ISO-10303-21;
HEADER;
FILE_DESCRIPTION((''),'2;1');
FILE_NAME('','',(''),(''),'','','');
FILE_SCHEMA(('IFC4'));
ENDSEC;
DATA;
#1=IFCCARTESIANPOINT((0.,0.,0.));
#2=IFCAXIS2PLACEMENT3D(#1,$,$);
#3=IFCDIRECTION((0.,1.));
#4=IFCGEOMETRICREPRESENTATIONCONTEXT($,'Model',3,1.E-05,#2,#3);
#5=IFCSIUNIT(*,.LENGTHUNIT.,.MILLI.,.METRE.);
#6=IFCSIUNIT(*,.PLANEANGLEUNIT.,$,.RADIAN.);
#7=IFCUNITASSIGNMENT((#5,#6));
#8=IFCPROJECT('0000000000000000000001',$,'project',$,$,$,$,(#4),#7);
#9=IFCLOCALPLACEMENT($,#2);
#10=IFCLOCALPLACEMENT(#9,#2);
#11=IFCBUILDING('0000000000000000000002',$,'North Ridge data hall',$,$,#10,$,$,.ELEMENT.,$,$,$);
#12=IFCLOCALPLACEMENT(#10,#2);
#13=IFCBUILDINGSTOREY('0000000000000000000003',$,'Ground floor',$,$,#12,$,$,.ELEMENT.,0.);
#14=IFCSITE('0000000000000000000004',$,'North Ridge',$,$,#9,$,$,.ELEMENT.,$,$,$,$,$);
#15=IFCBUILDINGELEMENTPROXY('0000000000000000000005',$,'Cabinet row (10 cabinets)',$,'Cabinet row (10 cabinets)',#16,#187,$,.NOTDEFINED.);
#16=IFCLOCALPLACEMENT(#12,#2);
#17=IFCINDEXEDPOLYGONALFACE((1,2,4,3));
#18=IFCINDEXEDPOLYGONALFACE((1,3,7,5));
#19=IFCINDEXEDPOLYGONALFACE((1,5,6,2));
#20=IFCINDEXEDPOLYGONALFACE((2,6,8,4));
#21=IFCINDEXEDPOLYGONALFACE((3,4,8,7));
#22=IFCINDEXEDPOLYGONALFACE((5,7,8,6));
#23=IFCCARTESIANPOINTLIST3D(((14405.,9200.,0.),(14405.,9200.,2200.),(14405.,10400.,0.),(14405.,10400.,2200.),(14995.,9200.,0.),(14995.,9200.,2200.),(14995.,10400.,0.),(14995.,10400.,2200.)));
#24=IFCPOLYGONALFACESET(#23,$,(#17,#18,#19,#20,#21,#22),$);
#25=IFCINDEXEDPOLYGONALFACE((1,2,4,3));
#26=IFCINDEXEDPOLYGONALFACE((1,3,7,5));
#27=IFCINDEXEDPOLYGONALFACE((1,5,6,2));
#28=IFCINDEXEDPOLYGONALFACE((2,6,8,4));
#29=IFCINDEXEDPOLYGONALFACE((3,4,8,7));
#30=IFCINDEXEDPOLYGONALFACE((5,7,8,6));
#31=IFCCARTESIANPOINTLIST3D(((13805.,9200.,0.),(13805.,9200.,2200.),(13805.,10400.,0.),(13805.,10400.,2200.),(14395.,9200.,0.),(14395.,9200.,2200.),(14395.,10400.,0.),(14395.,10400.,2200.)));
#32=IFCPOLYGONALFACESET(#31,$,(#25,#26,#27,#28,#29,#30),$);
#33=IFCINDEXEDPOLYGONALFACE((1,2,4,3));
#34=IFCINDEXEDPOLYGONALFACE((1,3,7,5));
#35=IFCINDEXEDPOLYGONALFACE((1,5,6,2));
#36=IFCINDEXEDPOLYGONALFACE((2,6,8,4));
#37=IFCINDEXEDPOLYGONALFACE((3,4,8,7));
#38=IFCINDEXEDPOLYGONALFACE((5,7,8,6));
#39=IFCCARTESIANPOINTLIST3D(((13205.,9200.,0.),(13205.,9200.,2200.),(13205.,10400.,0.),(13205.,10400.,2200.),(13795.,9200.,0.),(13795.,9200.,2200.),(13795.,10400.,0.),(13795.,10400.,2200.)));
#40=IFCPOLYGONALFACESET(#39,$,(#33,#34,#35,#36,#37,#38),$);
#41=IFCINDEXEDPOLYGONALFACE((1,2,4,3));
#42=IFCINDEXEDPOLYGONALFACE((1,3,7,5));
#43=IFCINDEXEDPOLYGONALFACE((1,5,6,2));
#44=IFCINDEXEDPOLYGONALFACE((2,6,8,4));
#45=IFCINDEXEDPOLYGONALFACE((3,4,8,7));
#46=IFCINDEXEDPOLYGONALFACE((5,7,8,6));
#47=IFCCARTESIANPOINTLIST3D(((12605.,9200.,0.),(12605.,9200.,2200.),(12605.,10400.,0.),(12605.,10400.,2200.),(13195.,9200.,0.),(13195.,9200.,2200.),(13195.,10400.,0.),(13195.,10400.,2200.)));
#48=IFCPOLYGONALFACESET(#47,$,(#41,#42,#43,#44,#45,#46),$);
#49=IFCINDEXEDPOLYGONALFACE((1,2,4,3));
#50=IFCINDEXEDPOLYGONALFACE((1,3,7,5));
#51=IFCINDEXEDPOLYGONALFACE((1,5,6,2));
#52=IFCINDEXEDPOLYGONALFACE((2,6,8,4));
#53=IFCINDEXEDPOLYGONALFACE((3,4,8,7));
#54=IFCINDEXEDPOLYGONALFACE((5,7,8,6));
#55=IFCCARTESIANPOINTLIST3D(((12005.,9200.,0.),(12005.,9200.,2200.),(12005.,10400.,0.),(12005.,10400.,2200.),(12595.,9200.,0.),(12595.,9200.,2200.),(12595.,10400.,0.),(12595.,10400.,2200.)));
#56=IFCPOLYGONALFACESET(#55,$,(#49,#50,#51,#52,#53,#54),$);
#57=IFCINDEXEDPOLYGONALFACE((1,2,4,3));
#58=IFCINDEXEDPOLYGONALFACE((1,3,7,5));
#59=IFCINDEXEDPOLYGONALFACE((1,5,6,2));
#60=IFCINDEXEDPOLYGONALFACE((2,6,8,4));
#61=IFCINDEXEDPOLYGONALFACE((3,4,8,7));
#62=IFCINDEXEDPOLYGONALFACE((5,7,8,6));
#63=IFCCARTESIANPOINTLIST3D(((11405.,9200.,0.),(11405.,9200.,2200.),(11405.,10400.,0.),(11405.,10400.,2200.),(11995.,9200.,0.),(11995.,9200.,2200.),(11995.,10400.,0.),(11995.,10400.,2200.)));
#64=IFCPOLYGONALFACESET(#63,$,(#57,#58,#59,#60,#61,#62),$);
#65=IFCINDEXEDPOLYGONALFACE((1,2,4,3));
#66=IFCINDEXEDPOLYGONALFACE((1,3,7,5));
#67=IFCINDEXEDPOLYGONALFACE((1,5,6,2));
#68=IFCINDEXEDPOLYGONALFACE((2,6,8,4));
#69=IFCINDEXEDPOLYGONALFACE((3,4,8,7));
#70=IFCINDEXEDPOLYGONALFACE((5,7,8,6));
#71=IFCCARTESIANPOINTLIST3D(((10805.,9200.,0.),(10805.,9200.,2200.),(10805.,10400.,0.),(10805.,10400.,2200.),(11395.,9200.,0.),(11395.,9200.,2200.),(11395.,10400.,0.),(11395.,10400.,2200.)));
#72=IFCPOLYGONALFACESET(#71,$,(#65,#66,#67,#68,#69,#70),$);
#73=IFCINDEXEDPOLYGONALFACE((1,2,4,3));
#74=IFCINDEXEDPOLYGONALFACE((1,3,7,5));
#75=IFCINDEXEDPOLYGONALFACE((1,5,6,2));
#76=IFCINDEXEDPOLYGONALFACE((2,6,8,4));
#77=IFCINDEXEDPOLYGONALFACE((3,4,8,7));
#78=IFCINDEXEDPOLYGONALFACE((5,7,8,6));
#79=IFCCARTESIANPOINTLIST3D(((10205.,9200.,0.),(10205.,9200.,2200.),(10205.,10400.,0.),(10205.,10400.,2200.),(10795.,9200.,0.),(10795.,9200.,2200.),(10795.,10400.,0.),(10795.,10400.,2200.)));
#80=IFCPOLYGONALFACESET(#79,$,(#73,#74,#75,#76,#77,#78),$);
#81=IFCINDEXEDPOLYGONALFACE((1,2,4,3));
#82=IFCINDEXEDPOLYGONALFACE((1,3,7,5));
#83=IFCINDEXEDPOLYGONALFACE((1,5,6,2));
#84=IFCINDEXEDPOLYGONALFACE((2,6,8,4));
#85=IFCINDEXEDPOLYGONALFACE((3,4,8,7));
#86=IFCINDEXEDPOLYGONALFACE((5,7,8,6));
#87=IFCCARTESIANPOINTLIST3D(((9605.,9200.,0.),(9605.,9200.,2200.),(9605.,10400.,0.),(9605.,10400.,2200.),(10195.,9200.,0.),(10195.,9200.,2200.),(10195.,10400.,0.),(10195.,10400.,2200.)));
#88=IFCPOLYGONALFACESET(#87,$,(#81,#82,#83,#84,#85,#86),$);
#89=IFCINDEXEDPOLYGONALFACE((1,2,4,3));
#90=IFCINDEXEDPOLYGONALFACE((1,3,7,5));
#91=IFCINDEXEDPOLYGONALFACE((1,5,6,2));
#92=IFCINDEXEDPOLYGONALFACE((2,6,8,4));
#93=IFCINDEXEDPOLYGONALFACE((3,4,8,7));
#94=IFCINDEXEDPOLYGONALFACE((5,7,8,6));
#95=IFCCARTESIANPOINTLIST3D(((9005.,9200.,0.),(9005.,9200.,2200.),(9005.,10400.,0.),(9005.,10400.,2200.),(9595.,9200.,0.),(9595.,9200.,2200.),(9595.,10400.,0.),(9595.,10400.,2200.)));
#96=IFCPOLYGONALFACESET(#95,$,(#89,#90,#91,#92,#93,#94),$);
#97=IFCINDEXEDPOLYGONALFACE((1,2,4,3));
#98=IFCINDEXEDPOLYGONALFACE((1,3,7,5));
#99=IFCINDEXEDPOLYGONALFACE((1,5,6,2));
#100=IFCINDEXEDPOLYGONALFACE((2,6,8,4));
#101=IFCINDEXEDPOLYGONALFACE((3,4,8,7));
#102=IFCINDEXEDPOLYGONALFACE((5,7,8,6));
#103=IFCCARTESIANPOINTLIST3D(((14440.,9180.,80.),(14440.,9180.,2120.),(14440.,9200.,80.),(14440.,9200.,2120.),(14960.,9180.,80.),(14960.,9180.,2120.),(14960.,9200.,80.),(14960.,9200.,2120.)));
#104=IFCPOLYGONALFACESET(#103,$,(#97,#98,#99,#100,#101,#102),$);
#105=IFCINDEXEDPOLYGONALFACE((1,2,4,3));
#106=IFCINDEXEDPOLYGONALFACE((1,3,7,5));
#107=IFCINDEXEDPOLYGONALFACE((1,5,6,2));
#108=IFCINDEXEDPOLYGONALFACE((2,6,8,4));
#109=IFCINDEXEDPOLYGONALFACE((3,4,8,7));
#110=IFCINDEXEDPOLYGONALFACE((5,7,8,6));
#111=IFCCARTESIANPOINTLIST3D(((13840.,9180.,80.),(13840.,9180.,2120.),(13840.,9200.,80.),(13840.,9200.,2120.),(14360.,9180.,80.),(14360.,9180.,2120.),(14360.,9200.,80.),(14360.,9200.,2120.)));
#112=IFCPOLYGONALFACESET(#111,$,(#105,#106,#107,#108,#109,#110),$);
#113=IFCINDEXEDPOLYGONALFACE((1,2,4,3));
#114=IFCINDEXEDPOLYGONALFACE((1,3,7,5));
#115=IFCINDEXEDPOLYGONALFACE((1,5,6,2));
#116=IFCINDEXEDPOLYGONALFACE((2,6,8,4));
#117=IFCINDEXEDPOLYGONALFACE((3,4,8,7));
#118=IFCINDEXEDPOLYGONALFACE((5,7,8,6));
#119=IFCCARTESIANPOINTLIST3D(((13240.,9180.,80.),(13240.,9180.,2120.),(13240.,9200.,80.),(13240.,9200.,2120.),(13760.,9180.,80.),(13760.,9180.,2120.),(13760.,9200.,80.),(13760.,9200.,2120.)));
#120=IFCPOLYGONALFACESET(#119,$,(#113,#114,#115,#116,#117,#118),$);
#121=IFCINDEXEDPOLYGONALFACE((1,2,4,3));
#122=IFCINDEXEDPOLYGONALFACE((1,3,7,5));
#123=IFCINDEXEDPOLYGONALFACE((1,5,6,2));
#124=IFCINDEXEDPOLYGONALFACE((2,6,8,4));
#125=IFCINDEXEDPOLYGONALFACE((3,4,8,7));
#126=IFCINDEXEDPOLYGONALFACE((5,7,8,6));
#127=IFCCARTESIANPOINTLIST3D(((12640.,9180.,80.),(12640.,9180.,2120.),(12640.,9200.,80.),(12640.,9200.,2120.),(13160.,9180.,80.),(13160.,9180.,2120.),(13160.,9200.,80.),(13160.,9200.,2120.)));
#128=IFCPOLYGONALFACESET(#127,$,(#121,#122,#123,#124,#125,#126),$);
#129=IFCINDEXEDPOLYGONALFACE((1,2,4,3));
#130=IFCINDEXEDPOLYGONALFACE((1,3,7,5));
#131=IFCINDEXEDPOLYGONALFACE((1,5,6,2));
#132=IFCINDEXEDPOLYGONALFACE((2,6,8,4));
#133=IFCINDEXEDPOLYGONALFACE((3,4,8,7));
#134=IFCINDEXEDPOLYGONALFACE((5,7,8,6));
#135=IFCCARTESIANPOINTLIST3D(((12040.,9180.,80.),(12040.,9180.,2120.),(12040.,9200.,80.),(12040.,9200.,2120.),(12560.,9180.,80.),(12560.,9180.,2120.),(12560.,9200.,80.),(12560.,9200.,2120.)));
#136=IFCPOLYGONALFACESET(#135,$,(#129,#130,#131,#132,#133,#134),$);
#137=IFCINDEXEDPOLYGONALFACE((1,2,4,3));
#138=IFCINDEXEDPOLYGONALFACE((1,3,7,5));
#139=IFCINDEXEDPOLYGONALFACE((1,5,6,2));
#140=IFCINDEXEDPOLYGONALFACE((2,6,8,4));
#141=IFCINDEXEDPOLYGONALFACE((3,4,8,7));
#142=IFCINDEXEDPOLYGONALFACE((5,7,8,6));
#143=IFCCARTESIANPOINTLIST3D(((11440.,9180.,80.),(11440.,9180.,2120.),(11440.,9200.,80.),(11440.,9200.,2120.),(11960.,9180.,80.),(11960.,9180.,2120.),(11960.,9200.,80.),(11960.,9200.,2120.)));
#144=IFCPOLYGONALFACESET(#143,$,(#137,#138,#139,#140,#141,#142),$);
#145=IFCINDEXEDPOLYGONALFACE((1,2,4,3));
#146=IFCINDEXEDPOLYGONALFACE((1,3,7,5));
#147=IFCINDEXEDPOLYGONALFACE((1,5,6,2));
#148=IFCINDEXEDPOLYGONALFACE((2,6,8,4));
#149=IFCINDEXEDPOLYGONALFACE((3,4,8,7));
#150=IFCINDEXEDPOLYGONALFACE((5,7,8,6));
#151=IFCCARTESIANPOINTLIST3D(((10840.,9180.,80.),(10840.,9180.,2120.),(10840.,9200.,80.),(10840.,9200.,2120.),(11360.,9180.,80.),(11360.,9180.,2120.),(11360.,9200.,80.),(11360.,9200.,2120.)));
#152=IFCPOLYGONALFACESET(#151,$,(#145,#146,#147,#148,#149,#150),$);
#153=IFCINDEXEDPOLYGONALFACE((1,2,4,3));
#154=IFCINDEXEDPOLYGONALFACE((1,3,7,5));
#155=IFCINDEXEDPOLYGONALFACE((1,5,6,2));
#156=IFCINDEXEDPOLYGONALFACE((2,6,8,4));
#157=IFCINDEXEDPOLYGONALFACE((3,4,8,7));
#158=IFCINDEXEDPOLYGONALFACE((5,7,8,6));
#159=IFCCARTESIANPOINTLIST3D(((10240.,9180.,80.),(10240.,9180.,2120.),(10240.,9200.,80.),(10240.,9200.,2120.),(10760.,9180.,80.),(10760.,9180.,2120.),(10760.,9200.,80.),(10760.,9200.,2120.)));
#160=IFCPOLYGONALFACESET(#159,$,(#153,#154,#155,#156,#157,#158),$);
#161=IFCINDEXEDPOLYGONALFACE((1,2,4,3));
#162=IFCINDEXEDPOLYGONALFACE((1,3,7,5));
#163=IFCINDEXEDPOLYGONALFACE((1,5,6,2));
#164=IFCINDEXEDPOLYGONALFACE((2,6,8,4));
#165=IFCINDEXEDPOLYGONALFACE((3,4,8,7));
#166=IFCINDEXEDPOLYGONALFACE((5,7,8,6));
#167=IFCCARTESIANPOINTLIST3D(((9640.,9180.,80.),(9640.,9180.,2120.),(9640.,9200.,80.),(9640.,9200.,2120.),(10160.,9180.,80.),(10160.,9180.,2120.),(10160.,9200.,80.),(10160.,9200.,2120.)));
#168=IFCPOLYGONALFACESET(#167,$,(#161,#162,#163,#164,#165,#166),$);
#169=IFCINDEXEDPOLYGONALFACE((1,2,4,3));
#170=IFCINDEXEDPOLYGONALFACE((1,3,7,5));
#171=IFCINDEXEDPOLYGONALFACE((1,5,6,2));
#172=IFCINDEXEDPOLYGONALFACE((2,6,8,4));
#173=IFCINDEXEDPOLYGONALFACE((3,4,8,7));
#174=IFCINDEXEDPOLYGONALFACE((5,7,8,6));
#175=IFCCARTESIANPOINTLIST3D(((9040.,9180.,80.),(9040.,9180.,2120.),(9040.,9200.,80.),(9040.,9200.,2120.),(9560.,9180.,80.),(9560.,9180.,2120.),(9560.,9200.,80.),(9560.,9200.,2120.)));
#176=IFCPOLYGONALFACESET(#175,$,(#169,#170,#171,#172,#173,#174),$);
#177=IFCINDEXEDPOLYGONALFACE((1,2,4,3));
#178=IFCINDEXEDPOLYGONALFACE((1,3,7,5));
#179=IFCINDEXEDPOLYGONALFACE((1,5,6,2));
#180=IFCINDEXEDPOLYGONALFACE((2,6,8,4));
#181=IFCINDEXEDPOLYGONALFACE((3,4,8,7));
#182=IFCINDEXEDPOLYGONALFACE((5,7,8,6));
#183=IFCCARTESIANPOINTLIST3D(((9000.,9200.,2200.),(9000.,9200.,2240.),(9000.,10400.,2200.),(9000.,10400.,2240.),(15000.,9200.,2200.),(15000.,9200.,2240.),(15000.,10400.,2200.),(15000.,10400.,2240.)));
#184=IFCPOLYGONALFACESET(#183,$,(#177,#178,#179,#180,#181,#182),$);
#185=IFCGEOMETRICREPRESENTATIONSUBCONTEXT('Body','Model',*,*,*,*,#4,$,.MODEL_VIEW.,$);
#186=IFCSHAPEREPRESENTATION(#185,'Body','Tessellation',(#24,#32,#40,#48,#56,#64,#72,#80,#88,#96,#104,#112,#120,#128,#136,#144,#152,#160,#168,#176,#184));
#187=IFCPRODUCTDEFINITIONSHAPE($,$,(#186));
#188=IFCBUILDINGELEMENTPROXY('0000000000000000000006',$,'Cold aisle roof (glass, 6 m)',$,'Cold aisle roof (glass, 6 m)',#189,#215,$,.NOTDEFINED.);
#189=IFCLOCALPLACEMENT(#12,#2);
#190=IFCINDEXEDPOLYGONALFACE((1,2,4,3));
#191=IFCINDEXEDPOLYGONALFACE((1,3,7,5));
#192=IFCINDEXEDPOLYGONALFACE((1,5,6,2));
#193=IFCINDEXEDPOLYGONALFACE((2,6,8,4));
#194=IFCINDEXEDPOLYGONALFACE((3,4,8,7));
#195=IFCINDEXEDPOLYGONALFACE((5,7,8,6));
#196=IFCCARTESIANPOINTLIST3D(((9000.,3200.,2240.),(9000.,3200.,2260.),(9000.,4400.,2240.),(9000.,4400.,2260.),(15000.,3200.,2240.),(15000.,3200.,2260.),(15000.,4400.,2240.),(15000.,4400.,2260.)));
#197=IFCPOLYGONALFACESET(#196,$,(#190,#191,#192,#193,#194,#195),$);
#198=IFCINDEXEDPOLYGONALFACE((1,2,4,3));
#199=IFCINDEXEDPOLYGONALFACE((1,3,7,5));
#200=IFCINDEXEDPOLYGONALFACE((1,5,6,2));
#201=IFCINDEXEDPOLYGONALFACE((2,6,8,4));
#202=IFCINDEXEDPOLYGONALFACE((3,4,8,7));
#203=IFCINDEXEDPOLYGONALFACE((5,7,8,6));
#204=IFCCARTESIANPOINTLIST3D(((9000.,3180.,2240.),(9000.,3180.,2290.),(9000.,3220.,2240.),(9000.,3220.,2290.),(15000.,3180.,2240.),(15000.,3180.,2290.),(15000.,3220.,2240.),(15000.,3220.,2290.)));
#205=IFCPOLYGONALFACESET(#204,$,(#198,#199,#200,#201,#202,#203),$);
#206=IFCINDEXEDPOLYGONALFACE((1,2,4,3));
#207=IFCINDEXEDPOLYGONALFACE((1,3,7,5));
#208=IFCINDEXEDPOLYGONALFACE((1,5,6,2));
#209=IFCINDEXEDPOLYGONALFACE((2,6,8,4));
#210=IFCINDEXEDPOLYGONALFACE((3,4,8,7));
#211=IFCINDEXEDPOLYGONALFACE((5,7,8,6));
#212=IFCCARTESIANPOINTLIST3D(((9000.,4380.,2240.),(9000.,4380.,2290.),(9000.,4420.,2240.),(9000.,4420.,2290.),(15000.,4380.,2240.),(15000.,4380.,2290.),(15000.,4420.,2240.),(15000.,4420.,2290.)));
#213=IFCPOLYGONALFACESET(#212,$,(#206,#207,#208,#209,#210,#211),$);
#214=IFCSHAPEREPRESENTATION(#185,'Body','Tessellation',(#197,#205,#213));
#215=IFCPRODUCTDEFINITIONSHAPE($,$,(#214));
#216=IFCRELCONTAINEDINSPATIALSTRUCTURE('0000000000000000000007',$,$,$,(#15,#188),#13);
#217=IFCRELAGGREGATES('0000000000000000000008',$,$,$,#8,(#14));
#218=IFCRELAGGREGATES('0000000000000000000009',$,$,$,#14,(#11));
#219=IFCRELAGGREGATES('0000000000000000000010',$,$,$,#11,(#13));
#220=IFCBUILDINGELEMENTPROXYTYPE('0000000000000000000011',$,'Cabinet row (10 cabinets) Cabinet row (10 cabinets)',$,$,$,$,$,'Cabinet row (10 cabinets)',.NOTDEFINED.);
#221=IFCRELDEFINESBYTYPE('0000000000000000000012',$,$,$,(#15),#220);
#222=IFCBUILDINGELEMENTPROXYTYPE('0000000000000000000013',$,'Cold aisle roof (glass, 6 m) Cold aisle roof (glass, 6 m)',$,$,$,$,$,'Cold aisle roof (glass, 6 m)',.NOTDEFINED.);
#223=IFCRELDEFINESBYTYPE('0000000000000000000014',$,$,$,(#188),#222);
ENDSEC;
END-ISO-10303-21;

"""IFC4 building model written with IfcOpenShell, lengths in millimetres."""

from ifc_helpers import new_model, si_unit, direction, frame, origin, place, context, subcontext, project, spatial, polyline, outline, extrude, source, transform, mapped, type_object, type_shapes, element, save


model = new_model("IFC4")

# Units and contexts
model_context = context("Model", 3, precision=1e-05, world=origin(), true_north=direction((0.0, 1.0)))
body_context = subcontext(model_context, "Body", "Model", "MODEL_VIEW")
ifc_project = project(units=[si_unit("LENGTHUNIT", "METRE", prefix="MILLI"), si_unit("PLANEANGLEUNIT", "RADIAN")], contexts=[model_context])

# Site, building, storey
site_placement = place(None, origin())
site = spatial("IfcSite", under=ifc_project, at=site_placement, Name="North Ridge", CompositionType="ELEMENT")
building_placement = place(site_placement, origin())
building = spatial("IfcBuilding", under=site, at=building_placement, Name="North Ridge data hall", CompositionType="ELEMENT")
storey_placement = place(building_placement, origin())
storey = spatial("IfcBuildingStorey", under=building, at=storey_placement, Name="Ground floor", CompositionType="ELEMENT", Elevation=0.0)

# Building element proxies
building_element_proxy_type_1 = type_object("IfcBuildingElementProxyType", Name="Cabinet row (10 cabinets) Cabinet row (10 cabinets)", ElementType="Cabinet row (10 cabinets)", PredefinedType="NOTDEFINED")
shared_shape_1 = source(origin(), body_context, "Body", "SweptSolid", [
    extrude(outline(polyline([(5.0, 0.0), (595.0, 0.0), (595.0, 1200.0), (5.0, 1200.0), (5.0, 0.0)])), origin(), (0.0, 0.0, 1.0), 2200.0),
    extrude(outline(polyline([(605.0, 0.0), (1195.0, 0.0), (1195.0, 1200.0), (605.0, 1200.0), (605.0, 0.0)])), origin(), (0.0, 0.0, 1.0), 2200.0),
    extrude(outline(polyline([(1205.0, 0.0), (1795.0, 0.0), (1795.0, 1200.0), (1205.0, 1200.0), (1205.0, 0.0)])), origin(), (0.0, 0.0, 1.0), 2200.0),
    extrude(outline(polyline([(1805.0, 0.0), (2395.0, 0.0), (2395.0, 1200.0), (1805.0, 1200.0), (1805.0, 0.0)])), origin(), (0.0, 0.0, 1.0), 2200.0),
    extrude(outline(polyline([(2405.0, 0.0), (2995.0, 0.0), (2995.0, 1200.0), (2405.0, 1200.0), (2405.0, 0.0)])), origin(), (0.0, 0.0, 1.0), 2200.0),
    extrude(outline(polyline([(3005.0, 0.0), (3595.0, 0.0), (3595.0, 1200.0), (3005.0, 1200.0), (3005.0, 0.0)])), origin(), (0.0, 0.0, 1.0), 2200.0),
    extrude(outline(polyline([(3605.0, 0.0), (4195.0, 0.0), (4195.0, 1200.0), (3605.0, 1200.0), (3605.0, 0.0)])), origin(), (0.0, 0.0, 1.0), 2200.0),
    extrude(outline(polyline([(4205.0, 0.0), (4795.0, 0.0), (4795.0, 1200.0), (4205.0, 1200.0), (4205.0, 0.0)])), origin(), (0.0, 0.0, 1.0), 2200.0),
    extrude(outline(polyline([(4805.0, 0.0), (5395.0, 0.0), (5395.0, 1200.0), (4805.0, 1200.0), (4805.0, 0.0)])), origin(), (0.0, 0.0, 1.0), 2200.0),
    extrude(outline(polyline([(5405.0, 0.0), (5995.0, 0.0), (5995.0, 1200.0), (5405.0, 1200.0), (5405.0, 0.0)])), origin(), (0.0, 0.0, 1.0), 2200.0),
    extrude(outline(polyline([(40.0, 1200.0), (560.0, 1200.0), (560.0, 1220.0), (40.0, 1220.0), (40.0, 1200.0)])), frame((0.0, 0.0, 80.0)), (0.0, 0.0, 1.0), 2040.0),
    extrude(outline(polyline([(640.0, 1200.0), (1160.0, 1200.0), (1160.0, 1220.0), (640.0, 1220.0), (640.0, 1200.0)])), frame((0.0, 0.0, 80.0)), (0.0, 0.0, 1.0), 2040.0),
    extrude(outline(polyline([(1240.0, 1200.0), (1760.0, 1200.0), (1760.0, 1220.0), (1240.0, 1220.0), (1240.0, 1200.0)])), frame((0.0, 0.0, 80.0)), (0.0, 0.0, 1.0), 2040.0),
    extrude(outline(polyline([(1840.0, 1200.0), (2360.0, 1200.0), (2360.0, 1220.0), (1840.0, 1220.0), (1840.0, 1200.0)])), frame((0.0, 0.0, 80.0)), (0.0, 0.0, 1.0), 2040.0),
    extrude(outline(polyline([(2440.0, 1200.0), (2960.0, 1200.0), (2960.0, 1220.0), (2440.0, 1220.0), (2440.0, 1200.0)])), frame((0.0, 0.0, 80.0)), (0.0, 0.0, 1.0), 2040.0),
    extrude(outline(polyline([(3040.0, 1200.0), (3560.0, 1200.0), (3560.0, 1220.0), (3040.0, 1220.0), (3040.0, 1200.0)])), frame((0.0, 0.0, 80.0)), (0.0, 0.0, 1.0), 2040.0),
    extrude(outline(polyline([(3640.0, 1200.0), (4160.0, 1200.0), (4160.0, 1220.0), (3640.0, 1220.0), (3640.0, 1200.0)])), frame((0.0, 0.0, 80.0)), (0.0, 0.0, 1.0), 2040.0),
    extrude(outline(polyline([(4240.0, 1200.0), (4760.0, 1200.0), (4760.0, 1220.0), (4240.0, 1220.0), (4240.0, 1200.0)])), frame((0.0, 0.0, 80.0)), (0.0, 0.0, 1.0), 2040.0),
    extrude(outline(polyline([(4840.0, 1200.0), (5360.0, 1200.0), (5360.0, 1220.0), (4840.0, 1220.0), (4840.0, 1200.0)])), frame((0.0, 0.0, 80.0)), (0.0, 0.0, 1.0), 2040.0),
    extrude(outline(polyline([(5440.0, 1200.0), (5960.0, 1200.0), (5960.0, 1220.0), (5440.0, 1220.0), (5440.0, 1200.0)])), frame((0.0, 0.0, 80.0)), (0.0, 0.0, 1.0), 2040.0),
    extrude(outline(polyline([(0.0, 0.0), (6000.0, 0.0), (6000.0, 1200.0), (0.0, 1200.0), (0.0, 0.0)])), frame((0.0, 0.0, 2200.0)), (0.0, 0.0, 1.0), 40.0),
])
type_shapes(building_element_proxy_type_1, [shared_shape_1])
for number, where, z_axis, x_axis, name in (
    (1, (15000.0, 10400.0, 0.0), (0.0, 0.0, 1.0), (-1.0, 0.0, 0.0), "Cabinet row (10 cabinets)"),
):
    element("IfcBuildingElementProxy", number, at=place(storey_placement, frame(where, z_axis=z_axis, x_axis=x_axis)), inside=storey, type_object=building_element_proxy_type_1, Name=name, ObjectType="Cabinet row (10 cabinets)", PredefinedType="NOTDEFINED", context=body_context, shape_type="MappedRepresentation", body=[
        mapped(shared_shape_1, transform((0.0, 0.0, 0.0))),
    ])
building_element_proxy_type_2 = type_object("IfcBuildingElementProxyType", Name="Cold aisle roof (glass, 6 m) Cold aisle roof (glass, 6 m)", ElementType="Cold aisle roof (glass, 6 m)", PredefinedType="NOTDEFINED")
shared_shape_2 = source(origin(), body_context, "Body", "SweptSolid", [
    extrude(outline(polyline([(0.0, 0.0), (6000.0, 0.0), (6000.0, 1200.0), (0.0, 1200.0), (0.0, 0.0)])), frame((0.0, 0.0, 2240.0)), (0.0, 0.0, 1.0), 20.0),
    extrude(outline(polyline([(0.0, -20.0), (6000.0, -20.0), (6000.0, 20.0), (0.0, 20.0), (0.0, -20.0)])), frame((0.0, 0.0, 2240.0)), (0.0, 0.0, 1.0), 50.0),
    extrude(outline(polyline([(0.0, 1180.0), (6000.0, 1180.0), (6000.0, 1220.0), (0.0, 1220.0), (0.0, 1180.0)])), frame((0.0, 0.0, 2240.0)), (0.0, 0.0, 1.0), 50.0),
])
type_shapes(building_element_proxy_type_2, [shared_shape_2])
for number, where, z_axis, x_axis, name in (
    (2, (9000.0, 3200.0, 0.0), (0.0, 0.0, 1.0), (1.0, 0.0, 0.0), "Cold aisle roof (glass, 6 m)"),
):
    element("IfcBuildingElementProxy", number, at=place(storey_placement, frame(where, z_axis=z_axis, x_axis=x_axis)), inside=storey, type_object=building_element_proxy_type_2, Name=name, ObjectType="Cold aisle roof (glass, 6 m)", PredefinedType="NOTDEFINED", context=body_context, shape_type="MappedRepresentation", body=[
        mapped(shared_shape_2, transform((0.0, 0.0, 0.0))),
    ])

save(model, "model.ifc")
